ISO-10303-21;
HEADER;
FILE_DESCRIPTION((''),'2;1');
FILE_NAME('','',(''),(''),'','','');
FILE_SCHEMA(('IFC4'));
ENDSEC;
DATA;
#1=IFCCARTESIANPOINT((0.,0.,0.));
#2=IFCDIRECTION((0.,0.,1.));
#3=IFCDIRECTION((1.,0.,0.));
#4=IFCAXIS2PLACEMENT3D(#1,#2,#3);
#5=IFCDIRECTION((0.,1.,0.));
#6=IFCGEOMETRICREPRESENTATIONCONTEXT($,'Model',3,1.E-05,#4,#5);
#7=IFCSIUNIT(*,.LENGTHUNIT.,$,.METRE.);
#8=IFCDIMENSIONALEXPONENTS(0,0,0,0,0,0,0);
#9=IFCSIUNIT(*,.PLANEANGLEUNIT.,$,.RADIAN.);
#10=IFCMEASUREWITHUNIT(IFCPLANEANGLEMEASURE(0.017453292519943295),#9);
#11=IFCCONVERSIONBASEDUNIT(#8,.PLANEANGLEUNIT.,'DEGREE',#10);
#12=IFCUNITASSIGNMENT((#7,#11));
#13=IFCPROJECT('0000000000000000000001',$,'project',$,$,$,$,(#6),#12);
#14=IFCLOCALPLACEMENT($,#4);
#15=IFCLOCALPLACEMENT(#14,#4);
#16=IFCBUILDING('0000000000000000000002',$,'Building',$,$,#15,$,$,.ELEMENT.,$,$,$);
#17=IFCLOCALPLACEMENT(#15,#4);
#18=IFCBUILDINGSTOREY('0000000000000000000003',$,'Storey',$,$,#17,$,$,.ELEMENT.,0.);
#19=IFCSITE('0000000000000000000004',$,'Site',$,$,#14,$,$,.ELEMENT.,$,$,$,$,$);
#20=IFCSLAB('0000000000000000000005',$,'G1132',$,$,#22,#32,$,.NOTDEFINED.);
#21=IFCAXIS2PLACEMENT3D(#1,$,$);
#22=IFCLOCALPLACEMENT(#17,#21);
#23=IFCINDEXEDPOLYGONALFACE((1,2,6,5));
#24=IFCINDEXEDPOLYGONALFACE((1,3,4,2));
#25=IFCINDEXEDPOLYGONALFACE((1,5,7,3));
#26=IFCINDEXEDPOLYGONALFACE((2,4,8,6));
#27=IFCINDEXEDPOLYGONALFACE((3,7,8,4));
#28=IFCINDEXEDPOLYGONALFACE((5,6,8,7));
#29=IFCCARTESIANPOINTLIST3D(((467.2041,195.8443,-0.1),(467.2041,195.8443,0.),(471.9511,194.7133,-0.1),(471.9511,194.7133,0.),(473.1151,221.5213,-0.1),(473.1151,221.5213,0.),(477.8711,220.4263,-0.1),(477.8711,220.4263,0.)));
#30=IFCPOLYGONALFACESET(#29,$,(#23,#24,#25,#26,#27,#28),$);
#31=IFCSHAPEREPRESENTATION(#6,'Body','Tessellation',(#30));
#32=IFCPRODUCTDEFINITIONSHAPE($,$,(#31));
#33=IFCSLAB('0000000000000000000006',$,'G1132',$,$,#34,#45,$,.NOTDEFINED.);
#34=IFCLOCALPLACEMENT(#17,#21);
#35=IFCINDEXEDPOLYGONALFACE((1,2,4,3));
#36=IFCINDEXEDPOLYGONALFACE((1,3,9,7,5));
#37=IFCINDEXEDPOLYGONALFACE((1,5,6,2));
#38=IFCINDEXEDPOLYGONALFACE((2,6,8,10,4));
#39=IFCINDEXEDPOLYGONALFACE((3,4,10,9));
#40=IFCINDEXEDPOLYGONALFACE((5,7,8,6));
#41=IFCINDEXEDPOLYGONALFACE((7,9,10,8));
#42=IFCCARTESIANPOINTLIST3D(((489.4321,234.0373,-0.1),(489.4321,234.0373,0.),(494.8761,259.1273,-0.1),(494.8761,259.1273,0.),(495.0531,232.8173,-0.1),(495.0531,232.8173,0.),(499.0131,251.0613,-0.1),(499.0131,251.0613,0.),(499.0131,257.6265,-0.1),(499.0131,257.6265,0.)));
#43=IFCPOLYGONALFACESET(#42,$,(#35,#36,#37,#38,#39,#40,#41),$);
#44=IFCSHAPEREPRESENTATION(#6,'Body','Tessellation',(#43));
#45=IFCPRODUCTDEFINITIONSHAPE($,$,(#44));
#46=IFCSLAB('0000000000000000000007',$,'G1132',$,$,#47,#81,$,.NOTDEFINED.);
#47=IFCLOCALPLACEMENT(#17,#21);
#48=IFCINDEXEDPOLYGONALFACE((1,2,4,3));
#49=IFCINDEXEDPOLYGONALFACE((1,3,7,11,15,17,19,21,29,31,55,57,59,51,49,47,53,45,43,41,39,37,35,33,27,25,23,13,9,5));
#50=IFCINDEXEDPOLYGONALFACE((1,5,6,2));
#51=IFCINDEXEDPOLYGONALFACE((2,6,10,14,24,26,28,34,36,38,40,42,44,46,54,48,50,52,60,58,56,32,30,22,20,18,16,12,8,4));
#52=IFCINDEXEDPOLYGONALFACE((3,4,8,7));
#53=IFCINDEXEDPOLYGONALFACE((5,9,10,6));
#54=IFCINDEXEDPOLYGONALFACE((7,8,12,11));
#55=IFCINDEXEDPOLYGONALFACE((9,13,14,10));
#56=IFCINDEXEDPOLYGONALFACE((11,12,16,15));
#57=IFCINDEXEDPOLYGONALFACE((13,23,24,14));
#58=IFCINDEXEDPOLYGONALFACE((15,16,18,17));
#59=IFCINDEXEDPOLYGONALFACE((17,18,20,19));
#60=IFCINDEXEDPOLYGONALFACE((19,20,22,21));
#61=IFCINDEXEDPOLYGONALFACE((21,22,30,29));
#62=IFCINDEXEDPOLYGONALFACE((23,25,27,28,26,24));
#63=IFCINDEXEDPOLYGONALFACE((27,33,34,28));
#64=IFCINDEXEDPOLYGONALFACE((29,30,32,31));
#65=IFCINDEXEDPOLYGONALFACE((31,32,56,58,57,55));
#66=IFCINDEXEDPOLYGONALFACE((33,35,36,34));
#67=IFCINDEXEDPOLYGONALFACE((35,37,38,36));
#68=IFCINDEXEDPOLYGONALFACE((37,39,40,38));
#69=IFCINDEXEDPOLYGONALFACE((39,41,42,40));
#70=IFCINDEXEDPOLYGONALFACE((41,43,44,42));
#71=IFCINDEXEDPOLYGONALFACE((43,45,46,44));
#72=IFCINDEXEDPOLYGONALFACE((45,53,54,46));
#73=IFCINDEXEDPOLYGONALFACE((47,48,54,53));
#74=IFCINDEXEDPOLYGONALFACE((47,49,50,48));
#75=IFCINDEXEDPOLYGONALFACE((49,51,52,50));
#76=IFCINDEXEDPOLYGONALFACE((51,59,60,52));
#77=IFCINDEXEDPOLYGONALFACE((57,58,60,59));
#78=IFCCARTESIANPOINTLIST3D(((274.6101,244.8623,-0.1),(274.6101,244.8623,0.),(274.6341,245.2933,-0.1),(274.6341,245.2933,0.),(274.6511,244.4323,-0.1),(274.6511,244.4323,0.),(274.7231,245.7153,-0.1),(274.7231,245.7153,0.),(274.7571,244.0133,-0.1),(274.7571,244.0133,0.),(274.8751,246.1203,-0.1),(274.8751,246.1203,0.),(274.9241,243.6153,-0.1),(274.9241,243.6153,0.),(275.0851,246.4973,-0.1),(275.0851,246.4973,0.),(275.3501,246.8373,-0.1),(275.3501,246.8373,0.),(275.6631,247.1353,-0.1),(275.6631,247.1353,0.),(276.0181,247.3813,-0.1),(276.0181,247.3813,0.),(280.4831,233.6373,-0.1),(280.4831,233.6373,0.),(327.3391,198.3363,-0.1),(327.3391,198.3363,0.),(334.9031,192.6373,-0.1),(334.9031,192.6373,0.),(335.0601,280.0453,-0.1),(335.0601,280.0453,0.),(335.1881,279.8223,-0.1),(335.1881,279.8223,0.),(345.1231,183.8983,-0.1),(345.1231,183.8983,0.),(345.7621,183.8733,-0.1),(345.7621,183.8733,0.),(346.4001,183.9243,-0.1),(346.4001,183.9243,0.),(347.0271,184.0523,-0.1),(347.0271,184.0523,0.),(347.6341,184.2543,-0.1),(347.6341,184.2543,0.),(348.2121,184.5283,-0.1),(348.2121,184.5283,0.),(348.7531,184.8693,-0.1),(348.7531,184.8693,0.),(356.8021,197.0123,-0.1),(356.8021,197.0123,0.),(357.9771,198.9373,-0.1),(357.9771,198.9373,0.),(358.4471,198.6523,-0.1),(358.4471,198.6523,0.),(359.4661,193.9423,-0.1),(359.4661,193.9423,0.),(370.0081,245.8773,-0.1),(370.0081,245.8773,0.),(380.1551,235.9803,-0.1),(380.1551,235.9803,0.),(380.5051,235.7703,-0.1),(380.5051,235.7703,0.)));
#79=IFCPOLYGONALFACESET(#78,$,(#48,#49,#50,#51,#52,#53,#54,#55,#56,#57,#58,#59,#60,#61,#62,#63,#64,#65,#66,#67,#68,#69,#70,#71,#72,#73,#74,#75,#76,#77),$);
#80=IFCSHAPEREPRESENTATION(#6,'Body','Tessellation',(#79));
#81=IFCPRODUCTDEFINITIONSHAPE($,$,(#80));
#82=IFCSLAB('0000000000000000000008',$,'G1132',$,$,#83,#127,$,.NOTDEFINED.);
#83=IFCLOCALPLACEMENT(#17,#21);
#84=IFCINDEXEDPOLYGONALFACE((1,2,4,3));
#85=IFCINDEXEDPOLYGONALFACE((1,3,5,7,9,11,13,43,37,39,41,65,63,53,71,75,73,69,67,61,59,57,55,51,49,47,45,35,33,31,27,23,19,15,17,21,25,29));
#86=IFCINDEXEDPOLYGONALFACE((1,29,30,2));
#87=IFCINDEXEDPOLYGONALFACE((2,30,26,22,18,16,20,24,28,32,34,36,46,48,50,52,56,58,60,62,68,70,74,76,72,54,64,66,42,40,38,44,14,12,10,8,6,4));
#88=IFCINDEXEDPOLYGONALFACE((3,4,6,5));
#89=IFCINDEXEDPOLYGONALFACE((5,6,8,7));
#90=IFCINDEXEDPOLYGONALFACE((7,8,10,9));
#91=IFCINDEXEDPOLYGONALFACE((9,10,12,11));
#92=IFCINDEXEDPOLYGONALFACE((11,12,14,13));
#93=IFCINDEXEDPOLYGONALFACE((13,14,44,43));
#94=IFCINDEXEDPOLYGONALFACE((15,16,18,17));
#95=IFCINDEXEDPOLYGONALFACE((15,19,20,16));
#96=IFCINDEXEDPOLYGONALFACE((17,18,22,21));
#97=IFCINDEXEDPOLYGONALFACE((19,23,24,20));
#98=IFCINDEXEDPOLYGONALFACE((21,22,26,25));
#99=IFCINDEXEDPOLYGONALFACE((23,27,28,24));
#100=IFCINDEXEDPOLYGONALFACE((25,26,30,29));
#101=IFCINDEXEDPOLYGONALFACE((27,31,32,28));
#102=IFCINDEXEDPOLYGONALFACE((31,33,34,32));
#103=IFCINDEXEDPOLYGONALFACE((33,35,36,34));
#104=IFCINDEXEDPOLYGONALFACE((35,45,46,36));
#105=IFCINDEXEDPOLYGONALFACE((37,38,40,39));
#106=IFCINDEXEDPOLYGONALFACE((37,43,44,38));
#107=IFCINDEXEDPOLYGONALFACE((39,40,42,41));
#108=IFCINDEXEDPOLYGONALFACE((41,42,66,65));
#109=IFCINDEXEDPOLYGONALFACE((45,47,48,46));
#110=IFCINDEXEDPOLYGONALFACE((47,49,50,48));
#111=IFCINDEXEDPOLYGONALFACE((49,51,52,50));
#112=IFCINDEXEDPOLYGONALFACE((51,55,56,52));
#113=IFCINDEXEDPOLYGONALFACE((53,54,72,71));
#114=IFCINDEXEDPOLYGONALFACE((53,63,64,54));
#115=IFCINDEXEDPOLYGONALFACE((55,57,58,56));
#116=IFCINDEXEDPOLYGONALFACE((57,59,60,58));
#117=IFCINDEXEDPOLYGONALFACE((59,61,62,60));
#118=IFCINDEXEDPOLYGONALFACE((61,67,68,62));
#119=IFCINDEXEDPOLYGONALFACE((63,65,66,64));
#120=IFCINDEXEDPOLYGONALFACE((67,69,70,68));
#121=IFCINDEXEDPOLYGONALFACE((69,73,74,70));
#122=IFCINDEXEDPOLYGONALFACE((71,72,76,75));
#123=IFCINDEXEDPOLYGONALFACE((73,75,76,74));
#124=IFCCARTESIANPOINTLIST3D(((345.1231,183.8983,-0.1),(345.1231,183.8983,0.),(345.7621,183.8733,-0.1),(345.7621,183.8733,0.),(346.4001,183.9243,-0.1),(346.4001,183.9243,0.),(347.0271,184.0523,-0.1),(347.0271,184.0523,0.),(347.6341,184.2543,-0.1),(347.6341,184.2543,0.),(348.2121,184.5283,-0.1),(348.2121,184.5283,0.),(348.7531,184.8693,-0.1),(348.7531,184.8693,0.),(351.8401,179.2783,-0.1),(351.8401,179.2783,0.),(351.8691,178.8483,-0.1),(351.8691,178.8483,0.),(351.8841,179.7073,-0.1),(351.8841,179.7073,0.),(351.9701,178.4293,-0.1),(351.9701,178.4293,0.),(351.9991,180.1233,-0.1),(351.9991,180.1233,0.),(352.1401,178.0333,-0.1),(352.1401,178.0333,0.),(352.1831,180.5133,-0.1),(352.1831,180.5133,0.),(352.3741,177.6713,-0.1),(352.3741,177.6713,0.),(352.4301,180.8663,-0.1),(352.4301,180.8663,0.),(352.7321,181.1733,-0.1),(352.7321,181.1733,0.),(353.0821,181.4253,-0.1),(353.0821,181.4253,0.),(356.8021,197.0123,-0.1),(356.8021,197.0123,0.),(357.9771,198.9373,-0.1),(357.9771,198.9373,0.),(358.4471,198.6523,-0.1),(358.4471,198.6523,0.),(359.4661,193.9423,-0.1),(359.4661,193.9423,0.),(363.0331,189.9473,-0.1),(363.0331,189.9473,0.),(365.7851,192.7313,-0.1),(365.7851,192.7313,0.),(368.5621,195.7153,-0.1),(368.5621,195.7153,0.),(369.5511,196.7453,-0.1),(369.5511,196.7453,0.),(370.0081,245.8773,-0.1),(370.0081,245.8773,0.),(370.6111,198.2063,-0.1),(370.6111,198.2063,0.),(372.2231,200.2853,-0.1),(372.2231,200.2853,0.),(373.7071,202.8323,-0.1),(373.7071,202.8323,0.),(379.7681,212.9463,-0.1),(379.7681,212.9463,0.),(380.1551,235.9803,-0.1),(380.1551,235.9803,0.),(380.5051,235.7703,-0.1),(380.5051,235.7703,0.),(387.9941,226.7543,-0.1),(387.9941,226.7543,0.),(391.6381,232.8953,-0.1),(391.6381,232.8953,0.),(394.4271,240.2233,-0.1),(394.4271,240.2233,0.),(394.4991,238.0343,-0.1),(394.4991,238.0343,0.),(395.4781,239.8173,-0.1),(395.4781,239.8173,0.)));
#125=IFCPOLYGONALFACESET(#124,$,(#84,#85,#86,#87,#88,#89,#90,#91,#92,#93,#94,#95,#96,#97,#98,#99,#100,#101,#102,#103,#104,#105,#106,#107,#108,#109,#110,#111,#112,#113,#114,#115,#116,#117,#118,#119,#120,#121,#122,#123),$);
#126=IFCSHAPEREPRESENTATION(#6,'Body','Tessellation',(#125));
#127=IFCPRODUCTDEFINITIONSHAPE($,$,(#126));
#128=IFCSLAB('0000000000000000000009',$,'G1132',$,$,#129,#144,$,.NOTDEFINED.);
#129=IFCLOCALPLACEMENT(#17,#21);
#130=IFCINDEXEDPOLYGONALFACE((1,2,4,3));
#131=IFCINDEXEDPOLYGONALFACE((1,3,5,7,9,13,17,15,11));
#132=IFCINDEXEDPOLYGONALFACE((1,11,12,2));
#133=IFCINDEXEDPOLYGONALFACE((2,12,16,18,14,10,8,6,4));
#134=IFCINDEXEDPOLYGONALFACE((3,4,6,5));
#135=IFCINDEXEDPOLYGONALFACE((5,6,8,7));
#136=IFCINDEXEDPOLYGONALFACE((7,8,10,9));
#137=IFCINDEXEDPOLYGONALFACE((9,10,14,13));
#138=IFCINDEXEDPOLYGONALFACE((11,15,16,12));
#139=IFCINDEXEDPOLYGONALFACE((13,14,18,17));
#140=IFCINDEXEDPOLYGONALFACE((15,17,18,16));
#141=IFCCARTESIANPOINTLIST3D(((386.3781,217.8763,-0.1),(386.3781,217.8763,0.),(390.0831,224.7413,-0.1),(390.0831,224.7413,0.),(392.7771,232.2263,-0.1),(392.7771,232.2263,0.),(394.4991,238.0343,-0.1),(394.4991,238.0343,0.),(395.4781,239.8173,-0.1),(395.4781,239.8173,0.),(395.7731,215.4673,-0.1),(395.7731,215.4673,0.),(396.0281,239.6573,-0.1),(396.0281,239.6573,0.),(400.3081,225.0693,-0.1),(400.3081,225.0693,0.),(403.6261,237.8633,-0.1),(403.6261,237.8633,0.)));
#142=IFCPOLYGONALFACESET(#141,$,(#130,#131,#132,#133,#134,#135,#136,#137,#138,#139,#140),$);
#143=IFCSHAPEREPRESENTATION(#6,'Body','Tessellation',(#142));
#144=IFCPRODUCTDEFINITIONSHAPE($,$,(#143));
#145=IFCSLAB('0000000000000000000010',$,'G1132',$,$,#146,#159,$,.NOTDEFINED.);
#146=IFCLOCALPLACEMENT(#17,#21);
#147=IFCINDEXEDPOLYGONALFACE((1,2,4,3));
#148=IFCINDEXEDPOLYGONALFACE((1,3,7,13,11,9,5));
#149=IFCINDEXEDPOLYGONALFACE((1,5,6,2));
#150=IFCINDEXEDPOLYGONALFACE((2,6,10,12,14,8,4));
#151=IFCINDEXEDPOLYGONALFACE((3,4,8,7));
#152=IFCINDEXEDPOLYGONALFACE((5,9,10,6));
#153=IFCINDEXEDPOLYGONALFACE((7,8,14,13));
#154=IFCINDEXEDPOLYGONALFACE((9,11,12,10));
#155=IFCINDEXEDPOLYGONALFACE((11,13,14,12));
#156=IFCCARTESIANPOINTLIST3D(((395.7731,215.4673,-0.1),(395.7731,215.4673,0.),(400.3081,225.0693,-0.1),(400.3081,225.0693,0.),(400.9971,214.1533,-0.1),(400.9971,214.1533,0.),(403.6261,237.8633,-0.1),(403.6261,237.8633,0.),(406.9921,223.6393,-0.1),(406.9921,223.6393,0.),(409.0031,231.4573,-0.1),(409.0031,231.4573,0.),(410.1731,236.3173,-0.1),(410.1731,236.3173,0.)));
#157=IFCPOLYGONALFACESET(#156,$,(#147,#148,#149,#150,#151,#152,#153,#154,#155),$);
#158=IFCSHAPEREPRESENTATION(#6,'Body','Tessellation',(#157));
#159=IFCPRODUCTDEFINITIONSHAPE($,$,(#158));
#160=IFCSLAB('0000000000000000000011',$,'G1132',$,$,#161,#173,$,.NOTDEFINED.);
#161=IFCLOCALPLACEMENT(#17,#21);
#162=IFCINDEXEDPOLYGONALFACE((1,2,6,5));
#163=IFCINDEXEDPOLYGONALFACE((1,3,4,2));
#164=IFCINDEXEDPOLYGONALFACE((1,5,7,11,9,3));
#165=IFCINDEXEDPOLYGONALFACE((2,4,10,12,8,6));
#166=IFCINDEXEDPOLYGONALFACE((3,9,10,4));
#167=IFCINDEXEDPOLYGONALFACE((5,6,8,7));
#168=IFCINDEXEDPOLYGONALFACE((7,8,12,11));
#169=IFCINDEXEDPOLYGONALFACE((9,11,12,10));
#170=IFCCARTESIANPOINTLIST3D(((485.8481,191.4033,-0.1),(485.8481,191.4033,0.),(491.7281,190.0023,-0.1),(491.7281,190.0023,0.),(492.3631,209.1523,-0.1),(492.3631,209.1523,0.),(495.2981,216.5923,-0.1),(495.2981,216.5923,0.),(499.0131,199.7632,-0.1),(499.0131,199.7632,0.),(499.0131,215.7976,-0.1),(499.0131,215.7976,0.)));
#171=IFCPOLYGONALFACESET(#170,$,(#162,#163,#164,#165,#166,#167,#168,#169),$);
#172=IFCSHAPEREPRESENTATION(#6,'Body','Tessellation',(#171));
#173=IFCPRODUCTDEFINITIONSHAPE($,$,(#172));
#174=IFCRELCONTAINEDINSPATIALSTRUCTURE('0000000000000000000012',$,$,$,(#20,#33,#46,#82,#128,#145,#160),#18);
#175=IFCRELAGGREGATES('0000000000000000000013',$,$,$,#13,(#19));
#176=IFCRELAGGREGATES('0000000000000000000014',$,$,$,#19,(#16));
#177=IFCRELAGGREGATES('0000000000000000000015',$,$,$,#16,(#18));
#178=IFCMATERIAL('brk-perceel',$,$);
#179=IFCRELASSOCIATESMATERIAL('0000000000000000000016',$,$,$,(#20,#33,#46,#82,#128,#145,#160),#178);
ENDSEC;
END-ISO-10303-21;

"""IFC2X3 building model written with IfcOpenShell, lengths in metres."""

from ifc_helpers import new_model, entity, si_unit, converted_unit, direction, frame, origin_with_axes, place, context, project, spatial, polyline, outline, extrude, material, element, save


model = new_model("IFC2X3")

# Units and contexts
model_context = context("Model", 3, precision=1e-05, world=origin_with_axes(), true_north=direction((0.0, 1.0, 0.0)))
ifc_project = project(units=[si_unit("LENGTHUNIT", "METRE"), converted_unit("PLANEANGLEUNIT", "DEGREE", entity("IfcPlaneAngleMeasure", 0.017453292519943295), si_unit("PLANEANGLEUNIT", "RADIAN"), dimensions=[0, 0, 0, 0, 0, 0, 0])], contexts=[model_context])

# Site, building, storey
site_placement = place(None, origin_with_axes())
site = spatial("IfcSite", under=ifc_project, at=site_placement, Name="Site", CompositionType="ELEMENT")
building_placement = place(site_placement, origin_with_axes())
building = spatial("IfcBuilding", under=site, at=building_placement, Name="Building", CompositionType="ELEMENT")
storey_placement = place(building_placement, origin_with_axes())
storey = spatial("IfcBuildingStorey", under=building, at=storey_placement, Name="Storey", CompositionType="ELEMENT", Elevation=0.0)

# Slabs
ifc_material = material(Name="brk-perceel")
slab_1_placement = place(storey_placement, frame((0.0, 0.0, -0.1), z_axis=(0.0, 0.0, 1.0), x_axis=(1.0, 0.0, 0.0)))
element("IfcSlab", 1, at=slab_1_placement, inside=storey, material=ifc_material, Name="G1132", PredefinedType="NOTDEFINED", context=model_context, shape_type="SweptSolid", body=[
    extrude(outline(polyline([(467.2041, 195.8443), (473.1151, 221.5213), (477.8711, 220.4263), (471.9511, 194.7133), (467.2041, 195.8443)])), origin_with_axes(), (0.0, 0.0, 1.0), 0.1),
])
slab_2_placement = place(storey_placement, frame((0.0, 0.0, -0.1), z_axis=(0.0, 0.0, 1.0), x_axis=(1.0, 0.0, 0.0)))
element("IfcSlab", 2, at=slab_2_placement, inside=storey, material=ifc_material, Name="G1132", PredefinedType="NOTDEFINED", context=model_context, shape_type="SweptSolid", body=[
    extrude(outline(polyline([(495.0531, 232.8173), (489.4321, 234.0373), (494.8761, 259.1273), (499.0131, 257.6265), (499.0131, 251.0613), (495.0531, 232.8173)])), origin_with_axes(), (0.0, 0.0, 1.0), 0.1),
])
slab_3_placement = place(storey_placement, frame((0.0, 0.0, -0.1), z_axis=(0.0, 0.0, 1.0), x_axis=(1.0, 0.0, 0.0)))
element("IfcSlab", 3, at=slab_3_placement, inside=storey, material=ifc_material, Name="G1132", PredefinedType="NOTDEFINED", context=model_context, shape_type="SweptSolid", body=[
    extrude(outline(polyline([(335.1881, 279.8223), (370.0081, 245.8773), (380.1551, 235.9803), (380.5051, 235.7703), (358.4471, 198.6523), (357.9771, 198.9373), (356.8021, 197.0123), (359.4661, 193.9423), (348.7531, 184.8693), (348.2121, 184.5283), (347.6341, 184.2543), (347.0271, 184.0523), (346.4001, 183.9243), (345.7621, 183.8733), (345.1231, 183.8983), (334.9031, 192.6373), (327.3391, 198.3363), (280.4831, 233.6373), (274.9241, 243.6153), (274.7571, 244.0133), (274.6511, 244.4323), (274.6101, 244.8623), (274.6341, 245.2933), (274.7231, 245.7153), (274.8751, 246.1203), (275.0851, 246.4973), (275.3501, 246.8373), (275.6631, 247.1353), (276.0181, 247.3813), (335.0601, 280.0453), (335.1881, 279.8223)])), origin_with_axes(), (0.0, 0.0, 1.0), 0.1),
])
slab_4_placement = place(storey_placement, frame((0.0, 0.0, -0.1), z_axis=(0.0, 0.0, 1.0), x_axis=(1.0, 0.0, 0.0)))
element("IfcSlab", 4, at=slab_4_placement, inside=storey, material=ifc_material, Name="G1132", PredefinedType="NOTDEFINED", context=model_context, shape_type="SweptSolid", body=[
    extrude(outline(polyline([(391.6381, 232.8953), (387.9941, 226.7543), (379.7681, 212.9463), (373.7071, 202.8323), (372.2231, 200.2853), (370.6111, 198.2063), (369.5511, 196.7453), (368.5621, 195.7153), (365.7851, 192.7313), (363.0331, 189.9473), (353.0821, 181.4253), (352.7321, 181.1733), (352.4301, 180.8663), (352.1831, 180.5133), (351.9991, 180.1233), (351.8841, 179.7073), (351.8401, 179.2783), (351.8691, 178.8483), (351.9701, 178.4293), (352.1401, 178.0333), (352.3741, 177.6713), (345.1231, 183.8983), (345.7621, 183.8733), (346.4001, 183.9243), (347.0271, 184.0523), (347.6341, 184.2543), (348.2121, 184.5283), (348.7531, 184.8693), (359.4661, 193.9423), (356.8021, 197.0123), (357.9771, 198.9373), (358.4471, 198.6523), (380.5051, 235.7703), (380.1551, 235.9803), (370.0081, 245.8773), (394.4271, 240.2233), (395.4781, 239.8173), (394.4991, 238.0343), (391.6381, 232.8953)])), origin_with_axes(), (0.0, 0.0, 1.0), 0.1),
])
slab_5_placement = place(storey_placement, frame((0.0, 0.0, -0.1), z_axis=(0.0, 0.0, 1.0), x_axis=(1.0, 0.0, 0.0)))
element("IfcSlab", 5, at=slab_5_placement, inside=storey, material=ifc_material, Name="G1132", PredefinedType="NOTDEFINED", context=model_context, shape_type="SweptSolid", body=[
    extrude(outline(polyline([(396.0281, 239.6573), (403.6261, 237.8633), (400.3081, 225.0693), (395.7731, 215.4673), (386.3781, 217.8763), (390.0831, 224.7413), (392.7771, 232.2263), (394.4991, 238.0343), (395.4781, 239.8173), (396.0281, 239.6573)])), origin_with_axes(), (0.0, 0.0, 1.0), 0.1),
])
slab_6_placement = place(storey_placement, frame((0.0, 0.0, -0.1), z_axis=(0.0, 0.0, 1.0), x_axis=(1.0, 0.0, 0.0)))
element("IfcSlab", 6, at=slab_6_placement, inside=storey, material=ifc_material, Name="G1132", PredefinedType="NOTDEFINED", context=model_context, shape_type="SweptSolid", body=[
    extrude(outline(polyline([(395.7731, 215.4673), (400.3081, 225.0693), (403.6261, 237.8633), (410.1731, 236.3173), (409.0031, 231.4573), (406.9921, 223.6393), (400.9971, 214.1533), (395.7731, 215.4673)])), origin_with_axes(), (0.0, 0.0, 1.0), 0.1),
])
slab_7_placement = place(storey_placement, frame((0.0, 0.0, -0.1), z_axis=(0.0, 0.0, 1.0), x_axis=(1.0, 0.0, 0.0)))
element("IfcSlab", 7, at=slab_7_placement, inside=storey, material=ifc_material, Name="G1132", PredefinedType="NOTDEFINED", context=model_context, shape_type="SweptSolid", body=[
    extrude(outline(polyline([(491.7281, 190.0023), (485.8481, 191.4033), (492.3631, 209.1523), (495.2981, 216.5923), (499.0131, 215.7976), (499.0131, 199.7632), (491.7281, 190.0023)])), origin_with_axes(), (0.0, 0.0, 1.0), 0.1),
])

save(model, "model.ifc")
